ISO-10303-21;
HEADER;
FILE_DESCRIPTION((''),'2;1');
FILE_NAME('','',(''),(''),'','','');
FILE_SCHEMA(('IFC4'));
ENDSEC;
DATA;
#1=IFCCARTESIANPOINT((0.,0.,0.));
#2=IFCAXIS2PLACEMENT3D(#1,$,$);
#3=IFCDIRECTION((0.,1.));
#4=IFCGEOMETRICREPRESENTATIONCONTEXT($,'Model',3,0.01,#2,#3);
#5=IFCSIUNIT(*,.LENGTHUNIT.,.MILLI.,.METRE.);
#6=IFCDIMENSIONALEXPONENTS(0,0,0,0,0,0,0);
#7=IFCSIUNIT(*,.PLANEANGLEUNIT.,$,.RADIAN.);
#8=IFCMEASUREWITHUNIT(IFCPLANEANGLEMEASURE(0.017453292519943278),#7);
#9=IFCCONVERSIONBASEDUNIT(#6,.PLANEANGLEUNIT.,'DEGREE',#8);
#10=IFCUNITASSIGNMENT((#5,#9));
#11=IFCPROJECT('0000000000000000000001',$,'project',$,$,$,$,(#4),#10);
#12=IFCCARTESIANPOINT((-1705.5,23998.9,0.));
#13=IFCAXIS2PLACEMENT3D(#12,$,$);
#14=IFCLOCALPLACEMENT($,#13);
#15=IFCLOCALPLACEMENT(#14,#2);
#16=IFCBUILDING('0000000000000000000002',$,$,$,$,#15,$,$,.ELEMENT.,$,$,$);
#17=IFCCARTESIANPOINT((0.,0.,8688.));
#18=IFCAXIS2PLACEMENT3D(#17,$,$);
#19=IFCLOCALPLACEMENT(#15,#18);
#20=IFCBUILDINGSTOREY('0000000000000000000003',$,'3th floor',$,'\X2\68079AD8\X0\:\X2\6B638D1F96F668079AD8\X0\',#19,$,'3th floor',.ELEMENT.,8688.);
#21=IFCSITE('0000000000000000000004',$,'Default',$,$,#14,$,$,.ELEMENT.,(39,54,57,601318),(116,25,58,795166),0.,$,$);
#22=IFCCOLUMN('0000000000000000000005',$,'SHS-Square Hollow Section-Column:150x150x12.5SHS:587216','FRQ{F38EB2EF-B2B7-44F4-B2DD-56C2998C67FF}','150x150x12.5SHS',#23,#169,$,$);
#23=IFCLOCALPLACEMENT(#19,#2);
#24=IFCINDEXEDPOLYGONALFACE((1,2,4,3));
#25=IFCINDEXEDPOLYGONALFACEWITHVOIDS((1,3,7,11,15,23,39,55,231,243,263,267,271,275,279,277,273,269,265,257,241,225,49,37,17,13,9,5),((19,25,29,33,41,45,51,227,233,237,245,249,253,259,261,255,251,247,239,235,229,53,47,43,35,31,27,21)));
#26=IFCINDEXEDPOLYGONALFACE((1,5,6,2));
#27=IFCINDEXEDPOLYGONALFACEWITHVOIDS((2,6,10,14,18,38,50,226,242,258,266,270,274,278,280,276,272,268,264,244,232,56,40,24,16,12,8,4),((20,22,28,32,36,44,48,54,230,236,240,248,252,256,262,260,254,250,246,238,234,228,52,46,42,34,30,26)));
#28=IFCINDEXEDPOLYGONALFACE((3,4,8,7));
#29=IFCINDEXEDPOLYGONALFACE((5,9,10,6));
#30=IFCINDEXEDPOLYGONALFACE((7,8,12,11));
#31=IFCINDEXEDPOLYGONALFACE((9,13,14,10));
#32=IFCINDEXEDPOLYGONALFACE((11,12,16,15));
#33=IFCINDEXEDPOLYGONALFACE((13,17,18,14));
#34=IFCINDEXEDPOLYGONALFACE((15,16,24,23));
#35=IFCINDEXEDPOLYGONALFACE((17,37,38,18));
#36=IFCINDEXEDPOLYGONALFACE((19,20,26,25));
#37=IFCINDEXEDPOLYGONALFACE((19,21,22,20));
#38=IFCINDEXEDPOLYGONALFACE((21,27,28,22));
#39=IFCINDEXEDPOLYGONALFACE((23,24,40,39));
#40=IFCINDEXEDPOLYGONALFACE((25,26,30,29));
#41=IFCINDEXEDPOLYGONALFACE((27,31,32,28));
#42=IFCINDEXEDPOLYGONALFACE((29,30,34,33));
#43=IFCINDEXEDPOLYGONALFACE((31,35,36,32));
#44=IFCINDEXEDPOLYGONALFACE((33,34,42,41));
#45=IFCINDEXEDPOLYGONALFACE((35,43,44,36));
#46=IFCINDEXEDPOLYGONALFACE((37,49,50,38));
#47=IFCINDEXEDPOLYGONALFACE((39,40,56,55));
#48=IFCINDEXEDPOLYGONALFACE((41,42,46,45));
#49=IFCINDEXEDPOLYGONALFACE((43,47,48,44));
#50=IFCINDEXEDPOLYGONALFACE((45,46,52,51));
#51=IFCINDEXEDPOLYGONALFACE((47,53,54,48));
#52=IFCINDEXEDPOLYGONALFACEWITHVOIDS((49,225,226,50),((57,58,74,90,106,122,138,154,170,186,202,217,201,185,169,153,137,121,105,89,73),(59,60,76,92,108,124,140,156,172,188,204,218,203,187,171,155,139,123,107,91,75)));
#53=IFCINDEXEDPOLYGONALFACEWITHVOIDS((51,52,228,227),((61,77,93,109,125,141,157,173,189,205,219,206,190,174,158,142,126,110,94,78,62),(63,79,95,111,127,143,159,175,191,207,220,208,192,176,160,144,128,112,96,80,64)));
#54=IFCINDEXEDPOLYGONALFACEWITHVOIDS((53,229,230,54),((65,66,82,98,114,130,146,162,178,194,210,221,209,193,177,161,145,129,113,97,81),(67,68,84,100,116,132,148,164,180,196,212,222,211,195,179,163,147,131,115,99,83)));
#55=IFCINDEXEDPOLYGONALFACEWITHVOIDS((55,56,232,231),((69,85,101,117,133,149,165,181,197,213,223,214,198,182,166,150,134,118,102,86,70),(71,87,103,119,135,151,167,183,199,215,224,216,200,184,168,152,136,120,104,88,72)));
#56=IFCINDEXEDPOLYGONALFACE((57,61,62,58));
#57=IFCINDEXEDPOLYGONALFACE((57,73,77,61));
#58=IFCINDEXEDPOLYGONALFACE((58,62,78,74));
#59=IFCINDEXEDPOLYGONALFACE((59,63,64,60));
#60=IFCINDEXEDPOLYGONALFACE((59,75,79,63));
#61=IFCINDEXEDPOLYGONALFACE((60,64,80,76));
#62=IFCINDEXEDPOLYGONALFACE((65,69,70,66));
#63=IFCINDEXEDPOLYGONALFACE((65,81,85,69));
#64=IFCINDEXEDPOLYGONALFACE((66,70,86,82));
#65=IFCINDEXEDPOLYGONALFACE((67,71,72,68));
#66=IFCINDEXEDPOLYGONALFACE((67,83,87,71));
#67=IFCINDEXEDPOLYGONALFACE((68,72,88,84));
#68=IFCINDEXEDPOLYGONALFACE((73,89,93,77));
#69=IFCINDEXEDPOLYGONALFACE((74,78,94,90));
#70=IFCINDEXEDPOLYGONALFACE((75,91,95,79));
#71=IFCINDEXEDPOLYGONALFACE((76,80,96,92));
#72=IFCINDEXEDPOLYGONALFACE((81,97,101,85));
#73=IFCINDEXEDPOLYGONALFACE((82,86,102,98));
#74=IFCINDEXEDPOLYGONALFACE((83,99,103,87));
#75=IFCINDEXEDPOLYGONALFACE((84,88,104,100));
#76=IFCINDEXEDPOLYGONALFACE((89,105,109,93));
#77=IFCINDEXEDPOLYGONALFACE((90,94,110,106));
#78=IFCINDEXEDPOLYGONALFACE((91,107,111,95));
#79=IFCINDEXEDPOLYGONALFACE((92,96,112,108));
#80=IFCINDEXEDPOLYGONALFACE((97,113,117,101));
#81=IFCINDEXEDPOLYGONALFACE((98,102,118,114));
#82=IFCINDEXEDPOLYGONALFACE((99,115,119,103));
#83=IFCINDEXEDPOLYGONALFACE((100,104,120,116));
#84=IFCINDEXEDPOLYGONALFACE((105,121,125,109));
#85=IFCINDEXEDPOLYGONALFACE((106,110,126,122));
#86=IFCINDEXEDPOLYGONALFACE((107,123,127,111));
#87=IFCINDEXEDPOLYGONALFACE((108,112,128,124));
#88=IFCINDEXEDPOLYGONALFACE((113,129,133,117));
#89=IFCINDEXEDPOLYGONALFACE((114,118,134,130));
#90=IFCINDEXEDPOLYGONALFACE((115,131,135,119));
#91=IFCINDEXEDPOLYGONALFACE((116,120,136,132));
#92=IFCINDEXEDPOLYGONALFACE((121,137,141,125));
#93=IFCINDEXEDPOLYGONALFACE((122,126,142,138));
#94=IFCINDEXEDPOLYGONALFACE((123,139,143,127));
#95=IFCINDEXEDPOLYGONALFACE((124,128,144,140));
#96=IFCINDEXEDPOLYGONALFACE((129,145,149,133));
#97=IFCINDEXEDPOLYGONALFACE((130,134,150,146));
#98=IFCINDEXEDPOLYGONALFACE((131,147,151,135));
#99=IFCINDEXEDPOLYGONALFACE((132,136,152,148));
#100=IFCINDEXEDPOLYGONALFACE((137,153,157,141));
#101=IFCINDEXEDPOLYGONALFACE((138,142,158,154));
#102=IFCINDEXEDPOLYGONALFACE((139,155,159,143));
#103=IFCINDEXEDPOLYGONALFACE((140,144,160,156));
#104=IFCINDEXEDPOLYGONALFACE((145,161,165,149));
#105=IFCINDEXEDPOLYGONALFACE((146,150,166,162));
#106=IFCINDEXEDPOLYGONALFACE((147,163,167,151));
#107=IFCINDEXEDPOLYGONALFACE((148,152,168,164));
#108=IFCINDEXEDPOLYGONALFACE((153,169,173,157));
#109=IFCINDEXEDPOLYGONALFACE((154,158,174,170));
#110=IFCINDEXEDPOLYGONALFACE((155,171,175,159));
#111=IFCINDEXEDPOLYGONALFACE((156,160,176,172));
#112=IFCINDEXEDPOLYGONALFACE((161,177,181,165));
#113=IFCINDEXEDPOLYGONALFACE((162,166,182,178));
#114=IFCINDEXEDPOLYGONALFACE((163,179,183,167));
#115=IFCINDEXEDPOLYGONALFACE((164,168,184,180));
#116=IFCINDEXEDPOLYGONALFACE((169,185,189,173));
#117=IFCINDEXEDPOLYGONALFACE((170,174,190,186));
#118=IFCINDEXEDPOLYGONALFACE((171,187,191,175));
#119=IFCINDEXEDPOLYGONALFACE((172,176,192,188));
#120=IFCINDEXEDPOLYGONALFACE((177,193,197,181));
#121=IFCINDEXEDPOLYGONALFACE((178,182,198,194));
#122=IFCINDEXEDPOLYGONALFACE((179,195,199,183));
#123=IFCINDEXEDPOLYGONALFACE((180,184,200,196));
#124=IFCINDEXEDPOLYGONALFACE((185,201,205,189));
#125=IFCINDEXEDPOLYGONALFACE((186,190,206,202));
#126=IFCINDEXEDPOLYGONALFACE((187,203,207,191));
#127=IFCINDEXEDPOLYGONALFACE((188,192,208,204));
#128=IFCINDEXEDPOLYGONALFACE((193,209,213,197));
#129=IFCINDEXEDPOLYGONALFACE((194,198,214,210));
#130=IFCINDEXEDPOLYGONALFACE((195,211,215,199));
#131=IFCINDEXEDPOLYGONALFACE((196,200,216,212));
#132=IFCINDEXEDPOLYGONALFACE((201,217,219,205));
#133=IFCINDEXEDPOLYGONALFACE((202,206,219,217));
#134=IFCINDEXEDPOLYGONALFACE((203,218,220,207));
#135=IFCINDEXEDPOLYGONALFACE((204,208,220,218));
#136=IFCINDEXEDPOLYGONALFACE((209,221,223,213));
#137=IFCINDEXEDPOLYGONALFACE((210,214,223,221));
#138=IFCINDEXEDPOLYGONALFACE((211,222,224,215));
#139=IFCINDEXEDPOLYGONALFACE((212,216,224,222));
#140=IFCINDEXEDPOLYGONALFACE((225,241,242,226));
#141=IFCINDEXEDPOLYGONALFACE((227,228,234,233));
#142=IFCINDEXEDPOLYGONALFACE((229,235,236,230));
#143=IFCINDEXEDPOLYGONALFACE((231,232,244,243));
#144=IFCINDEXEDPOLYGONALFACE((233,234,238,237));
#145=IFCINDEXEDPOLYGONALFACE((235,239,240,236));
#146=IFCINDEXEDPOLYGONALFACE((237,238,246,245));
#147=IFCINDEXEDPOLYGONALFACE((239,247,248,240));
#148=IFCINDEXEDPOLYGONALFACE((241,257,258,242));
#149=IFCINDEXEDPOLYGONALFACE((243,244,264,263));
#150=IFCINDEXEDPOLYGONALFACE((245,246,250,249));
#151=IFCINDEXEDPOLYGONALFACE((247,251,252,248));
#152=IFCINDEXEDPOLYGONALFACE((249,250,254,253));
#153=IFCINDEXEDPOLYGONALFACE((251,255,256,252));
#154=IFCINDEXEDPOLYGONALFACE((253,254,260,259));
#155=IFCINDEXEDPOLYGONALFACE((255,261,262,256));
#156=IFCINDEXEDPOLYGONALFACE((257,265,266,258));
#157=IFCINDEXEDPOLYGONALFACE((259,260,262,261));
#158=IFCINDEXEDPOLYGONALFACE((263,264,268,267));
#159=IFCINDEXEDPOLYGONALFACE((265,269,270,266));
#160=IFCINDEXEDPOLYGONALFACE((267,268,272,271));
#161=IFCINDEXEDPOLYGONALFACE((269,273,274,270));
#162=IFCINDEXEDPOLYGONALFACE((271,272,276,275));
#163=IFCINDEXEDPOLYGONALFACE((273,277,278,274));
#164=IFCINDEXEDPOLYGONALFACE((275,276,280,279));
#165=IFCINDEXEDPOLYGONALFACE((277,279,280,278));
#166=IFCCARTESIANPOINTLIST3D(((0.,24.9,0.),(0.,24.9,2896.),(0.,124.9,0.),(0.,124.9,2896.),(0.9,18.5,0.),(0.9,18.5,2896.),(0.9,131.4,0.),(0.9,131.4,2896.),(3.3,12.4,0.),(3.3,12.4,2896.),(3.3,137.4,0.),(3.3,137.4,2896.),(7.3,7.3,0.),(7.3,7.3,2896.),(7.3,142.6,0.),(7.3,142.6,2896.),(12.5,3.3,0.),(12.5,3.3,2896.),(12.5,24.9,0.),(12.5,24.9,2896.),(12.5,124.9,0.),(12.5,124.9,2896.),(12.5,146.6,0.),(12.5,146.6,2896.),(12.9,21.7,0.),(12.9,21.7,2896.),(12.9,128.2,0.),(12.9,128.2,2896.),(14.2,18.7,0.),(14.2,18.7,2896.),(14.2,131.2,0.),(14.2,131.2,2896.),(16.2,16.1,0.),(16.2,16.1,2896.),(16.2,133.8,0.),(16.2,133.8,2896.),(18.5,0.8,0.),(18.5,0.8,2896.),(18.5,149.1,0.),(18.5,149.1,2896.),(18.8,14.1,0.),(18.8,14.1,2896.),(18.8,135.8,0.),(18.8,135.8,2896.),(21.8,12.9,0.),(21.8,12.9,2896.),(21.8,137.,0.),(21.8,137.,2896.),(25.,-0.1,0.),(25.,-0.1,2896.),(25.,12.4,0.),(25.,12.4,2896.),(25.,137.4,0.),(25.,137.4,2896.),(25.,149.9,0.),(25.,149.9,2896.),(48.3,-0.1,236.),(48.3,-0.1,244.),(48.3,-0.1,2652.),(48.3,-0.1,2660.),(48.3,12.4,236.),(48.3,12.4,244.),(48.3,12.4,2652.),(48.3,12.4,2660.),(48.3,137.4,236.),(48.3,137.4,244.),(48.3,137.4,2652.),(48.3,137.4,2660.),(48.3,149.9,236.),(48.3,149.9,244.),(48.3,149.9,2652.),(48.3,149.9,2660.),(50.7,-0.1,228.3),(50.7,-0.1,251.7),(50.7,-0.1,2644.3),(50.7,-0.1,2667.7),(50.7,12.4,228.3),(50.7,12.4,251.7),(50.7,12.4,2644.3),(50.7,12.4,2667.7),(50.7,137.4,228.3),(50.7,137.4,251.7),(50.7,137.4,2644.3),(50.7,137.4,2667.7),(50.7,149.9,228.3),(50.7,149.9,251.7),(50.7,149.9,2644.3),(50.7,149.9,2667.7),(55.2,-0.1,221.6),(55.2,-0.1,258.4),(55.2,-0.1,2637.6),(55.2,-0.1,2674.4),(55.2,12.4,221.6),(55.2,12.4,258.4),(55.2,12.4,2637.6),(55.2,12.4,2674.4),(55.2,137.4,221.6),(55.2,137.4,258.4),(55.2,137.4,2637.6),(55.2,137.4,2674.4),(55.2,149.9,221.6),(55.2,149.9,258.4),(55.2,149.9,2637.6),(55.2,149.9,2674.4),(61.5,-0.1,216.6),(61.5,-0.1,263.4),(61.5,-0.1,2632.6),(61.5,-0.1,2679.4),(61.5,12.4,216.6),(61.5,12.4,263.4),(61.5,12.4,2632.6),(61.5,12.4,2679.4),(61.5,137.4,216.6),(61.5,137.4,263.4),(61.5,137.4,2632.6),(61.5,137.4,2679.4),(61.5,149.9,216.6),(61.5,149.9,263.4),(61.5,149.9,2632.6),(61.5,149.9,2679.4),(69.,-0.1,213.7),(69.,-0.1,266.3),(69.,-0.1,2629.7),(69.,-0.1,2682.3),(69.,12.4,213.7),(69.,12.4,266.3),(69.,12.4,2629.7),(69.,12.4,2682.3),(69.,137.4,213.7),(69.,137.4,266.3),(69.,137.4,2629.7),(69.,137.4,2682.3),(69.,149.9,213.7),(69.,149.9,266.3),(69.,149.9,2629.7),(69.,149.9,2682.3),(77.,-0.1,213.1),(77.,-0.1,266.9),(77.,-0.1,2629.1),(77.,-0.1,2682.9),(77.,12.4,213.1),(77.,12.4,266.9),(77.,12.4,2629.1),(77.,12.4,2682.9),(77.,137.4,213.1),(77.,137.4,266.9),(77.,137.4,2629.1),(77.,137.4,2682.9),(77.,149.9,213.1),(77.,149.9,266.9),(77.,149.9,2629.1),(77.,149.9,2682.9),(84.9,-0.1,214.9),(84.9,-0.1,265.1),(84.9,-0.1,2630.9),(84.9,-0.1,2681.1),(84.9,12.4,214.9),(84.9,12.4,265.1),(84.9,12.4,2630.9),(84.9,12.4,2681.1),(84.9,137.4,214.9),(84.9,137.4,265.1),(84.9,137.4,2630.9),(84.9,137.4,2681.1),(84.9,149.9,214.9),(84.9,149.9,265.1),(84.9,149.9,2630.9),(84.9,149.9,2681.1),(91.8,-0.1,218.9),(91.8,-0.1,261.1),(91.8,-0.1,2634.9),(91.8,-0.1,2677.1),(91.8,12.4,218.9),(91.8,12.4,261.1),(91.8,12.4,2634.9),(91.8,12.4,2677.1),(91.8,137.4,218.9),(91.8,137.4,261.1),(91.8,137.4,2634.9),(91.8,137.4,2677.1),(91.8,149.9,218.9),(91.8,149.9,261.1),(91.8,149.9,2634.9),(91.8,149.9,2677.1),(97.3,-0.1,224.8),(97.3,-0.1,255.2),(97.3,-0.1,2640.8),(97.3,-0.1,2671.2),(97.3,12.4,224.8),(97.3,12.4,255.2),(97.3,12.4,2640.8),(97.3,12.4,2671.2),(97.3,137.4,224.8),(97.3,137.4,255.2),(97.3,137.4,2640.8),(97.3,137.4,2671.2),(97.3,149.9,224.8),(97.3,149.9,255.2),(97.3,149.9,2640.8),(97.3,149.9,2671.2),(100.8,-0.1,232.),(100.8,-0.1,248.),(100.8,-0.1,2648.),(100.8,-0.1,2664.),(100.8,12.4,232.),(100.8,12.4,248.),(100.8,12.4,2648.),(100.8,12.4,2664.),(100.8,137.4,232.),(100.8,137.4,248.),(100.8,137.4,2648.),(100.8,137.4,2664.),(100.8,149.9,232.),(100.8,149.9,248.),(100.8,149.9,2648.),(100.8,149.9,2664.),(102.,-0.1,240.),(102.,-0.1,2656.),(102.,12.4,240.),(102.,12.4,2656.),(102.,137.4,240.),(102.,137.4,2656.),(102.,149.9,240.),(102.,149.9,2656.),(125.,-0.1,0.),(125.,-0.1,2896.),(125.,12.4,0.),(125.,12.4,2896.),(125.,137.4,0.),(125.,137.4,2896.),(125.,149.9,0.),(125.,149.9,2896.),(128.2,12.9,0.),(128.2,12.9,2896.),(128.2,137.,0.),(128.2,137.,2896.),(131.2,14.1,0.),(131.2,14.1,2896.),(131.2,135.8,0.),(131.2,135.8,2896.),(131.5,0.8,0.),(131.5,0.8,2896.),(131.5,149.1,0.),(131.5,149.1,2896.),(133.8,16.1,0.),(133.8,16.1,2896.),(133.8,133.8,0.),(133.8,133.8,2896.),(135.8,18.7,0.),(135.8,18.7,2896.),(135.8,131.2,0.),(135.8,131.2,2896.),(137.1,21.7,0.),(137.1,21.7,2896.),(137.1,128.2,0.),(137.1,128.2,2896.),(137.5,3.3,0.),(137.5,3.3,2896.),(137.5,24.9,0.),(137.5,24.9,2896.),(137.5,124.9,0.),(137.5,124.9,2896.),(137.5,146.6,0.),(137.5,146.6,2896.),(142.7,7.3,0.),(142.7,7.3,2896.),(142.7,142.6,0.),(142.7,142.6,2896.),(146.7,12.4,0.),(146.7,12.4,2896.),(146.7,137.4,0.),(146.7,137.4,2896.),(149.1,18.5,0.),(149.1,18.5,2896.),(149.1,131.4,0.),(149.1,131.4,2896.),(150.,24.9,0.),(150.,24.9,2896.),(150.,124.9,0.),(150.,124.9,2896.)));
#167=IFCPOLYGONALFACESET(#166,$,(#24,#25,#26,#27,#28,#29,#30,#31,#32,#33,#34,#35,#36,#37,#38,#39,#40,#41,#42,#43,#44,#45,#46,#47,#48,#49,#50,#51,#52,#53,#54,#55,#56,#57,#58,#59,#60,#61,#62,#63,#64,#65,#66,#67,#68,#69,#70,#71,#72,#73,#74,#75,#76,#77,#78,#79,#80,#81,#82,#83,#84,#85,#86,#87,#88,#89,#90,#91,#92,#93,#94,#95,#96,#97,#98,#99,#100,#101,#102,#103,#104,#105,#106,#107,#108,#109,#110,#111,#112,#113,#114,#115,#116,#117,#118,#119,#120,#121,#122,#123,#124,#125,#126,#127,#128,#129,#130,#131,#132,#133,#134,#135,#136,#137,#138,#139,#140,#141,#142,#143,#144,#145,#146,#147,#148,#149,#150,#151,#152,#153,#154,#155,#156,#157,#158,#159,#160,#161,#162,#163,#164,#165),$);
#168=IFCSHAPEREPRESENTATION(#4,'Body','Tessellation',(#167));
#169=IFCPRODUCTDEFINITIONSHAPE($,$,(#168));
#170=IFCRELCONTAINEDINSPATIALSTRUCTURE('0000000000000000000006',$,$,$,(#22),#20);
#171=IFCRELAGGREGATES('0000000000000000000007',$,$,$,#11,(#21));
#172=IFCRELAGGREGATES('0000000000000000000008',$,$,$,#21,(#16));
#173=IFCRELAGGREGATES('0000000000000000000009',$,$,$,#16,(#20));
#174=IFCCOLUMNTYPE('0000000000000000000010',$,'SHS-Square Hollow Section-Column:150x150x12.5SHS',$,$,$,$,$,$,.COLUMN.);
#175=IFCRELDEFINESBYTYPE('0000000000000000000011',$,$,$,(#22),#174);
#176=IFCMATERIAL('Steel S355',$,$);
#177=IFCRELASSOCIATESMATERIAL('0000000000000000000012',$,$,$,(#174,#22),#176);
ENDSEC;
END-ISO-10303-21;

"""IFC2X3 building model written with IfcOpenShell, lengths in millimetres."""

from ifc_helpers import new_model, entity, si_unit, converted_unit, direction, frame, frame_2d, origin, origin_2d, place, context, project, spatial, circle_curve, hollow_rectangle, outline, extrude, material, type_object, element, save


model = new_model("IFC2X3")

# Units and contexts
model_context = context("Model", 3, precision=0.01, world=origin(), true_north=direction((0.0, 1.0)))
ifc_project = project(units=[si_unit("LENGTHUNIT", "METRE", prefix="MILLI"), converted_unit("PLANEANGLEUNIT", "DEGREE", entity("IfcPlaneAngleMeasure", 0.017453292519943278), si_unit("PLANEANGLEUNIT", "RADIAN"), dimensions=[0, 0, 0, 0, 0, 0, 0])], contexts=[model_context])

# Site, building, storey
site_placement = place(None, frame((-1705.5, 23998.9, 0.0)))
site = spatial("IfcSite", under=ifc_project, at=site_placement, Name="Default", CompositionType="ELEMENT", RefLatitude=(39, 54, 57, 601318), RefLongitude=(116, 25, 58, 795166), RefElevation=0.0)
building_placement = place(site_placement, origin())
building = spatial("IfcBuilding", under=site, at=building_placement, CompositionType="ELEMENT")
storey_placement = place(building_placement, frame((0.0, 0.0, 8688.0)))
storey = spatial("IfcBuildingStorey", under=building, at=storey_placement, Name="3th floor", ObjectType="标高:正负零标高", LongName="3th floor", CompositionType="ELEMENT", Elevation=8688.0)

# Shared definitions
ifc_material_1 = material(Name="Steel S355")

# Column, openings
column_type_1 = type_object("IfcColumnType", Name="SHS-Square Hollow Section-Column:150x150x12.5SHS", PredefinedType="COLUMN", material=ifc_material_1)
column_1_placement = place(storey_placement, frame((75.0, 74.9, 2896.0), z_axis=(0.0, 0.0, 1.0), x_axis=(0.0, -1.0, 0.0)))
column_1 = element("IfcColumn", 1, at=column_1_placement, inside=storey, type_object=column_type_1, material=ifc_material_1, Name="SHS-Square Hollow Section-Column:150x150x12.5SHS:587216", Description="FRQ{F38EB2EF-B2B7-44F4-B2DD-56C2998C67FF}", ObjectType="150x150x12.5SHS", context=model_context, shape_type="SweptSolid", body=[
    extrude(hollow_rectangle(XDim=150.0, YDim=150.0, WallThickness=12.5, InnerFilletRadius=12.5, OuterFilletRadius=25.0, at=origin_2d()), origin(), (0.0, 0.0, -1.0), 2896.0),
])
opening_1_placement = place(column_1_placement, frame((-175.1, 0.0, -2896.0), z_axis=(1.0, 0.0, 0.0), x_axis=(0.0, 1.0, 0.0)))
element("IfcOpeningElement", 2, at=opening_1_placement, cuts=column_1, ObjectType="Opening", context=model_context, shape_type="SweptSolid", body=[
    extrude(outline(circle_curve(frame_2d((0.0, 240.0), x_axis=(1.0, 0.0)), 27.0)), origin(), (0.0, 0.0, 1.0), 350.2),
])
opening_2_placement = place(column_1_placement, frame((-175.1, 0.0, 0.0), z_axis=(1.0, 0.0, 0.0), x_axis=(0.0, 1.0, 0.0)))
element("IfcOpeningElement", 3, at=opening_2_placement, cuts=column_1, ObjectType="Opening", context=model_context, shape_type="SweptSolid", body=[
    extrude(outline(circle_curve(frame_2d((0.0, -240.0), x_axis=(1.0, 0.0)), 27.0)), origin(), (0.0, 0.0, 1.0), 350.2),
])

save(model, "model.ifc")
